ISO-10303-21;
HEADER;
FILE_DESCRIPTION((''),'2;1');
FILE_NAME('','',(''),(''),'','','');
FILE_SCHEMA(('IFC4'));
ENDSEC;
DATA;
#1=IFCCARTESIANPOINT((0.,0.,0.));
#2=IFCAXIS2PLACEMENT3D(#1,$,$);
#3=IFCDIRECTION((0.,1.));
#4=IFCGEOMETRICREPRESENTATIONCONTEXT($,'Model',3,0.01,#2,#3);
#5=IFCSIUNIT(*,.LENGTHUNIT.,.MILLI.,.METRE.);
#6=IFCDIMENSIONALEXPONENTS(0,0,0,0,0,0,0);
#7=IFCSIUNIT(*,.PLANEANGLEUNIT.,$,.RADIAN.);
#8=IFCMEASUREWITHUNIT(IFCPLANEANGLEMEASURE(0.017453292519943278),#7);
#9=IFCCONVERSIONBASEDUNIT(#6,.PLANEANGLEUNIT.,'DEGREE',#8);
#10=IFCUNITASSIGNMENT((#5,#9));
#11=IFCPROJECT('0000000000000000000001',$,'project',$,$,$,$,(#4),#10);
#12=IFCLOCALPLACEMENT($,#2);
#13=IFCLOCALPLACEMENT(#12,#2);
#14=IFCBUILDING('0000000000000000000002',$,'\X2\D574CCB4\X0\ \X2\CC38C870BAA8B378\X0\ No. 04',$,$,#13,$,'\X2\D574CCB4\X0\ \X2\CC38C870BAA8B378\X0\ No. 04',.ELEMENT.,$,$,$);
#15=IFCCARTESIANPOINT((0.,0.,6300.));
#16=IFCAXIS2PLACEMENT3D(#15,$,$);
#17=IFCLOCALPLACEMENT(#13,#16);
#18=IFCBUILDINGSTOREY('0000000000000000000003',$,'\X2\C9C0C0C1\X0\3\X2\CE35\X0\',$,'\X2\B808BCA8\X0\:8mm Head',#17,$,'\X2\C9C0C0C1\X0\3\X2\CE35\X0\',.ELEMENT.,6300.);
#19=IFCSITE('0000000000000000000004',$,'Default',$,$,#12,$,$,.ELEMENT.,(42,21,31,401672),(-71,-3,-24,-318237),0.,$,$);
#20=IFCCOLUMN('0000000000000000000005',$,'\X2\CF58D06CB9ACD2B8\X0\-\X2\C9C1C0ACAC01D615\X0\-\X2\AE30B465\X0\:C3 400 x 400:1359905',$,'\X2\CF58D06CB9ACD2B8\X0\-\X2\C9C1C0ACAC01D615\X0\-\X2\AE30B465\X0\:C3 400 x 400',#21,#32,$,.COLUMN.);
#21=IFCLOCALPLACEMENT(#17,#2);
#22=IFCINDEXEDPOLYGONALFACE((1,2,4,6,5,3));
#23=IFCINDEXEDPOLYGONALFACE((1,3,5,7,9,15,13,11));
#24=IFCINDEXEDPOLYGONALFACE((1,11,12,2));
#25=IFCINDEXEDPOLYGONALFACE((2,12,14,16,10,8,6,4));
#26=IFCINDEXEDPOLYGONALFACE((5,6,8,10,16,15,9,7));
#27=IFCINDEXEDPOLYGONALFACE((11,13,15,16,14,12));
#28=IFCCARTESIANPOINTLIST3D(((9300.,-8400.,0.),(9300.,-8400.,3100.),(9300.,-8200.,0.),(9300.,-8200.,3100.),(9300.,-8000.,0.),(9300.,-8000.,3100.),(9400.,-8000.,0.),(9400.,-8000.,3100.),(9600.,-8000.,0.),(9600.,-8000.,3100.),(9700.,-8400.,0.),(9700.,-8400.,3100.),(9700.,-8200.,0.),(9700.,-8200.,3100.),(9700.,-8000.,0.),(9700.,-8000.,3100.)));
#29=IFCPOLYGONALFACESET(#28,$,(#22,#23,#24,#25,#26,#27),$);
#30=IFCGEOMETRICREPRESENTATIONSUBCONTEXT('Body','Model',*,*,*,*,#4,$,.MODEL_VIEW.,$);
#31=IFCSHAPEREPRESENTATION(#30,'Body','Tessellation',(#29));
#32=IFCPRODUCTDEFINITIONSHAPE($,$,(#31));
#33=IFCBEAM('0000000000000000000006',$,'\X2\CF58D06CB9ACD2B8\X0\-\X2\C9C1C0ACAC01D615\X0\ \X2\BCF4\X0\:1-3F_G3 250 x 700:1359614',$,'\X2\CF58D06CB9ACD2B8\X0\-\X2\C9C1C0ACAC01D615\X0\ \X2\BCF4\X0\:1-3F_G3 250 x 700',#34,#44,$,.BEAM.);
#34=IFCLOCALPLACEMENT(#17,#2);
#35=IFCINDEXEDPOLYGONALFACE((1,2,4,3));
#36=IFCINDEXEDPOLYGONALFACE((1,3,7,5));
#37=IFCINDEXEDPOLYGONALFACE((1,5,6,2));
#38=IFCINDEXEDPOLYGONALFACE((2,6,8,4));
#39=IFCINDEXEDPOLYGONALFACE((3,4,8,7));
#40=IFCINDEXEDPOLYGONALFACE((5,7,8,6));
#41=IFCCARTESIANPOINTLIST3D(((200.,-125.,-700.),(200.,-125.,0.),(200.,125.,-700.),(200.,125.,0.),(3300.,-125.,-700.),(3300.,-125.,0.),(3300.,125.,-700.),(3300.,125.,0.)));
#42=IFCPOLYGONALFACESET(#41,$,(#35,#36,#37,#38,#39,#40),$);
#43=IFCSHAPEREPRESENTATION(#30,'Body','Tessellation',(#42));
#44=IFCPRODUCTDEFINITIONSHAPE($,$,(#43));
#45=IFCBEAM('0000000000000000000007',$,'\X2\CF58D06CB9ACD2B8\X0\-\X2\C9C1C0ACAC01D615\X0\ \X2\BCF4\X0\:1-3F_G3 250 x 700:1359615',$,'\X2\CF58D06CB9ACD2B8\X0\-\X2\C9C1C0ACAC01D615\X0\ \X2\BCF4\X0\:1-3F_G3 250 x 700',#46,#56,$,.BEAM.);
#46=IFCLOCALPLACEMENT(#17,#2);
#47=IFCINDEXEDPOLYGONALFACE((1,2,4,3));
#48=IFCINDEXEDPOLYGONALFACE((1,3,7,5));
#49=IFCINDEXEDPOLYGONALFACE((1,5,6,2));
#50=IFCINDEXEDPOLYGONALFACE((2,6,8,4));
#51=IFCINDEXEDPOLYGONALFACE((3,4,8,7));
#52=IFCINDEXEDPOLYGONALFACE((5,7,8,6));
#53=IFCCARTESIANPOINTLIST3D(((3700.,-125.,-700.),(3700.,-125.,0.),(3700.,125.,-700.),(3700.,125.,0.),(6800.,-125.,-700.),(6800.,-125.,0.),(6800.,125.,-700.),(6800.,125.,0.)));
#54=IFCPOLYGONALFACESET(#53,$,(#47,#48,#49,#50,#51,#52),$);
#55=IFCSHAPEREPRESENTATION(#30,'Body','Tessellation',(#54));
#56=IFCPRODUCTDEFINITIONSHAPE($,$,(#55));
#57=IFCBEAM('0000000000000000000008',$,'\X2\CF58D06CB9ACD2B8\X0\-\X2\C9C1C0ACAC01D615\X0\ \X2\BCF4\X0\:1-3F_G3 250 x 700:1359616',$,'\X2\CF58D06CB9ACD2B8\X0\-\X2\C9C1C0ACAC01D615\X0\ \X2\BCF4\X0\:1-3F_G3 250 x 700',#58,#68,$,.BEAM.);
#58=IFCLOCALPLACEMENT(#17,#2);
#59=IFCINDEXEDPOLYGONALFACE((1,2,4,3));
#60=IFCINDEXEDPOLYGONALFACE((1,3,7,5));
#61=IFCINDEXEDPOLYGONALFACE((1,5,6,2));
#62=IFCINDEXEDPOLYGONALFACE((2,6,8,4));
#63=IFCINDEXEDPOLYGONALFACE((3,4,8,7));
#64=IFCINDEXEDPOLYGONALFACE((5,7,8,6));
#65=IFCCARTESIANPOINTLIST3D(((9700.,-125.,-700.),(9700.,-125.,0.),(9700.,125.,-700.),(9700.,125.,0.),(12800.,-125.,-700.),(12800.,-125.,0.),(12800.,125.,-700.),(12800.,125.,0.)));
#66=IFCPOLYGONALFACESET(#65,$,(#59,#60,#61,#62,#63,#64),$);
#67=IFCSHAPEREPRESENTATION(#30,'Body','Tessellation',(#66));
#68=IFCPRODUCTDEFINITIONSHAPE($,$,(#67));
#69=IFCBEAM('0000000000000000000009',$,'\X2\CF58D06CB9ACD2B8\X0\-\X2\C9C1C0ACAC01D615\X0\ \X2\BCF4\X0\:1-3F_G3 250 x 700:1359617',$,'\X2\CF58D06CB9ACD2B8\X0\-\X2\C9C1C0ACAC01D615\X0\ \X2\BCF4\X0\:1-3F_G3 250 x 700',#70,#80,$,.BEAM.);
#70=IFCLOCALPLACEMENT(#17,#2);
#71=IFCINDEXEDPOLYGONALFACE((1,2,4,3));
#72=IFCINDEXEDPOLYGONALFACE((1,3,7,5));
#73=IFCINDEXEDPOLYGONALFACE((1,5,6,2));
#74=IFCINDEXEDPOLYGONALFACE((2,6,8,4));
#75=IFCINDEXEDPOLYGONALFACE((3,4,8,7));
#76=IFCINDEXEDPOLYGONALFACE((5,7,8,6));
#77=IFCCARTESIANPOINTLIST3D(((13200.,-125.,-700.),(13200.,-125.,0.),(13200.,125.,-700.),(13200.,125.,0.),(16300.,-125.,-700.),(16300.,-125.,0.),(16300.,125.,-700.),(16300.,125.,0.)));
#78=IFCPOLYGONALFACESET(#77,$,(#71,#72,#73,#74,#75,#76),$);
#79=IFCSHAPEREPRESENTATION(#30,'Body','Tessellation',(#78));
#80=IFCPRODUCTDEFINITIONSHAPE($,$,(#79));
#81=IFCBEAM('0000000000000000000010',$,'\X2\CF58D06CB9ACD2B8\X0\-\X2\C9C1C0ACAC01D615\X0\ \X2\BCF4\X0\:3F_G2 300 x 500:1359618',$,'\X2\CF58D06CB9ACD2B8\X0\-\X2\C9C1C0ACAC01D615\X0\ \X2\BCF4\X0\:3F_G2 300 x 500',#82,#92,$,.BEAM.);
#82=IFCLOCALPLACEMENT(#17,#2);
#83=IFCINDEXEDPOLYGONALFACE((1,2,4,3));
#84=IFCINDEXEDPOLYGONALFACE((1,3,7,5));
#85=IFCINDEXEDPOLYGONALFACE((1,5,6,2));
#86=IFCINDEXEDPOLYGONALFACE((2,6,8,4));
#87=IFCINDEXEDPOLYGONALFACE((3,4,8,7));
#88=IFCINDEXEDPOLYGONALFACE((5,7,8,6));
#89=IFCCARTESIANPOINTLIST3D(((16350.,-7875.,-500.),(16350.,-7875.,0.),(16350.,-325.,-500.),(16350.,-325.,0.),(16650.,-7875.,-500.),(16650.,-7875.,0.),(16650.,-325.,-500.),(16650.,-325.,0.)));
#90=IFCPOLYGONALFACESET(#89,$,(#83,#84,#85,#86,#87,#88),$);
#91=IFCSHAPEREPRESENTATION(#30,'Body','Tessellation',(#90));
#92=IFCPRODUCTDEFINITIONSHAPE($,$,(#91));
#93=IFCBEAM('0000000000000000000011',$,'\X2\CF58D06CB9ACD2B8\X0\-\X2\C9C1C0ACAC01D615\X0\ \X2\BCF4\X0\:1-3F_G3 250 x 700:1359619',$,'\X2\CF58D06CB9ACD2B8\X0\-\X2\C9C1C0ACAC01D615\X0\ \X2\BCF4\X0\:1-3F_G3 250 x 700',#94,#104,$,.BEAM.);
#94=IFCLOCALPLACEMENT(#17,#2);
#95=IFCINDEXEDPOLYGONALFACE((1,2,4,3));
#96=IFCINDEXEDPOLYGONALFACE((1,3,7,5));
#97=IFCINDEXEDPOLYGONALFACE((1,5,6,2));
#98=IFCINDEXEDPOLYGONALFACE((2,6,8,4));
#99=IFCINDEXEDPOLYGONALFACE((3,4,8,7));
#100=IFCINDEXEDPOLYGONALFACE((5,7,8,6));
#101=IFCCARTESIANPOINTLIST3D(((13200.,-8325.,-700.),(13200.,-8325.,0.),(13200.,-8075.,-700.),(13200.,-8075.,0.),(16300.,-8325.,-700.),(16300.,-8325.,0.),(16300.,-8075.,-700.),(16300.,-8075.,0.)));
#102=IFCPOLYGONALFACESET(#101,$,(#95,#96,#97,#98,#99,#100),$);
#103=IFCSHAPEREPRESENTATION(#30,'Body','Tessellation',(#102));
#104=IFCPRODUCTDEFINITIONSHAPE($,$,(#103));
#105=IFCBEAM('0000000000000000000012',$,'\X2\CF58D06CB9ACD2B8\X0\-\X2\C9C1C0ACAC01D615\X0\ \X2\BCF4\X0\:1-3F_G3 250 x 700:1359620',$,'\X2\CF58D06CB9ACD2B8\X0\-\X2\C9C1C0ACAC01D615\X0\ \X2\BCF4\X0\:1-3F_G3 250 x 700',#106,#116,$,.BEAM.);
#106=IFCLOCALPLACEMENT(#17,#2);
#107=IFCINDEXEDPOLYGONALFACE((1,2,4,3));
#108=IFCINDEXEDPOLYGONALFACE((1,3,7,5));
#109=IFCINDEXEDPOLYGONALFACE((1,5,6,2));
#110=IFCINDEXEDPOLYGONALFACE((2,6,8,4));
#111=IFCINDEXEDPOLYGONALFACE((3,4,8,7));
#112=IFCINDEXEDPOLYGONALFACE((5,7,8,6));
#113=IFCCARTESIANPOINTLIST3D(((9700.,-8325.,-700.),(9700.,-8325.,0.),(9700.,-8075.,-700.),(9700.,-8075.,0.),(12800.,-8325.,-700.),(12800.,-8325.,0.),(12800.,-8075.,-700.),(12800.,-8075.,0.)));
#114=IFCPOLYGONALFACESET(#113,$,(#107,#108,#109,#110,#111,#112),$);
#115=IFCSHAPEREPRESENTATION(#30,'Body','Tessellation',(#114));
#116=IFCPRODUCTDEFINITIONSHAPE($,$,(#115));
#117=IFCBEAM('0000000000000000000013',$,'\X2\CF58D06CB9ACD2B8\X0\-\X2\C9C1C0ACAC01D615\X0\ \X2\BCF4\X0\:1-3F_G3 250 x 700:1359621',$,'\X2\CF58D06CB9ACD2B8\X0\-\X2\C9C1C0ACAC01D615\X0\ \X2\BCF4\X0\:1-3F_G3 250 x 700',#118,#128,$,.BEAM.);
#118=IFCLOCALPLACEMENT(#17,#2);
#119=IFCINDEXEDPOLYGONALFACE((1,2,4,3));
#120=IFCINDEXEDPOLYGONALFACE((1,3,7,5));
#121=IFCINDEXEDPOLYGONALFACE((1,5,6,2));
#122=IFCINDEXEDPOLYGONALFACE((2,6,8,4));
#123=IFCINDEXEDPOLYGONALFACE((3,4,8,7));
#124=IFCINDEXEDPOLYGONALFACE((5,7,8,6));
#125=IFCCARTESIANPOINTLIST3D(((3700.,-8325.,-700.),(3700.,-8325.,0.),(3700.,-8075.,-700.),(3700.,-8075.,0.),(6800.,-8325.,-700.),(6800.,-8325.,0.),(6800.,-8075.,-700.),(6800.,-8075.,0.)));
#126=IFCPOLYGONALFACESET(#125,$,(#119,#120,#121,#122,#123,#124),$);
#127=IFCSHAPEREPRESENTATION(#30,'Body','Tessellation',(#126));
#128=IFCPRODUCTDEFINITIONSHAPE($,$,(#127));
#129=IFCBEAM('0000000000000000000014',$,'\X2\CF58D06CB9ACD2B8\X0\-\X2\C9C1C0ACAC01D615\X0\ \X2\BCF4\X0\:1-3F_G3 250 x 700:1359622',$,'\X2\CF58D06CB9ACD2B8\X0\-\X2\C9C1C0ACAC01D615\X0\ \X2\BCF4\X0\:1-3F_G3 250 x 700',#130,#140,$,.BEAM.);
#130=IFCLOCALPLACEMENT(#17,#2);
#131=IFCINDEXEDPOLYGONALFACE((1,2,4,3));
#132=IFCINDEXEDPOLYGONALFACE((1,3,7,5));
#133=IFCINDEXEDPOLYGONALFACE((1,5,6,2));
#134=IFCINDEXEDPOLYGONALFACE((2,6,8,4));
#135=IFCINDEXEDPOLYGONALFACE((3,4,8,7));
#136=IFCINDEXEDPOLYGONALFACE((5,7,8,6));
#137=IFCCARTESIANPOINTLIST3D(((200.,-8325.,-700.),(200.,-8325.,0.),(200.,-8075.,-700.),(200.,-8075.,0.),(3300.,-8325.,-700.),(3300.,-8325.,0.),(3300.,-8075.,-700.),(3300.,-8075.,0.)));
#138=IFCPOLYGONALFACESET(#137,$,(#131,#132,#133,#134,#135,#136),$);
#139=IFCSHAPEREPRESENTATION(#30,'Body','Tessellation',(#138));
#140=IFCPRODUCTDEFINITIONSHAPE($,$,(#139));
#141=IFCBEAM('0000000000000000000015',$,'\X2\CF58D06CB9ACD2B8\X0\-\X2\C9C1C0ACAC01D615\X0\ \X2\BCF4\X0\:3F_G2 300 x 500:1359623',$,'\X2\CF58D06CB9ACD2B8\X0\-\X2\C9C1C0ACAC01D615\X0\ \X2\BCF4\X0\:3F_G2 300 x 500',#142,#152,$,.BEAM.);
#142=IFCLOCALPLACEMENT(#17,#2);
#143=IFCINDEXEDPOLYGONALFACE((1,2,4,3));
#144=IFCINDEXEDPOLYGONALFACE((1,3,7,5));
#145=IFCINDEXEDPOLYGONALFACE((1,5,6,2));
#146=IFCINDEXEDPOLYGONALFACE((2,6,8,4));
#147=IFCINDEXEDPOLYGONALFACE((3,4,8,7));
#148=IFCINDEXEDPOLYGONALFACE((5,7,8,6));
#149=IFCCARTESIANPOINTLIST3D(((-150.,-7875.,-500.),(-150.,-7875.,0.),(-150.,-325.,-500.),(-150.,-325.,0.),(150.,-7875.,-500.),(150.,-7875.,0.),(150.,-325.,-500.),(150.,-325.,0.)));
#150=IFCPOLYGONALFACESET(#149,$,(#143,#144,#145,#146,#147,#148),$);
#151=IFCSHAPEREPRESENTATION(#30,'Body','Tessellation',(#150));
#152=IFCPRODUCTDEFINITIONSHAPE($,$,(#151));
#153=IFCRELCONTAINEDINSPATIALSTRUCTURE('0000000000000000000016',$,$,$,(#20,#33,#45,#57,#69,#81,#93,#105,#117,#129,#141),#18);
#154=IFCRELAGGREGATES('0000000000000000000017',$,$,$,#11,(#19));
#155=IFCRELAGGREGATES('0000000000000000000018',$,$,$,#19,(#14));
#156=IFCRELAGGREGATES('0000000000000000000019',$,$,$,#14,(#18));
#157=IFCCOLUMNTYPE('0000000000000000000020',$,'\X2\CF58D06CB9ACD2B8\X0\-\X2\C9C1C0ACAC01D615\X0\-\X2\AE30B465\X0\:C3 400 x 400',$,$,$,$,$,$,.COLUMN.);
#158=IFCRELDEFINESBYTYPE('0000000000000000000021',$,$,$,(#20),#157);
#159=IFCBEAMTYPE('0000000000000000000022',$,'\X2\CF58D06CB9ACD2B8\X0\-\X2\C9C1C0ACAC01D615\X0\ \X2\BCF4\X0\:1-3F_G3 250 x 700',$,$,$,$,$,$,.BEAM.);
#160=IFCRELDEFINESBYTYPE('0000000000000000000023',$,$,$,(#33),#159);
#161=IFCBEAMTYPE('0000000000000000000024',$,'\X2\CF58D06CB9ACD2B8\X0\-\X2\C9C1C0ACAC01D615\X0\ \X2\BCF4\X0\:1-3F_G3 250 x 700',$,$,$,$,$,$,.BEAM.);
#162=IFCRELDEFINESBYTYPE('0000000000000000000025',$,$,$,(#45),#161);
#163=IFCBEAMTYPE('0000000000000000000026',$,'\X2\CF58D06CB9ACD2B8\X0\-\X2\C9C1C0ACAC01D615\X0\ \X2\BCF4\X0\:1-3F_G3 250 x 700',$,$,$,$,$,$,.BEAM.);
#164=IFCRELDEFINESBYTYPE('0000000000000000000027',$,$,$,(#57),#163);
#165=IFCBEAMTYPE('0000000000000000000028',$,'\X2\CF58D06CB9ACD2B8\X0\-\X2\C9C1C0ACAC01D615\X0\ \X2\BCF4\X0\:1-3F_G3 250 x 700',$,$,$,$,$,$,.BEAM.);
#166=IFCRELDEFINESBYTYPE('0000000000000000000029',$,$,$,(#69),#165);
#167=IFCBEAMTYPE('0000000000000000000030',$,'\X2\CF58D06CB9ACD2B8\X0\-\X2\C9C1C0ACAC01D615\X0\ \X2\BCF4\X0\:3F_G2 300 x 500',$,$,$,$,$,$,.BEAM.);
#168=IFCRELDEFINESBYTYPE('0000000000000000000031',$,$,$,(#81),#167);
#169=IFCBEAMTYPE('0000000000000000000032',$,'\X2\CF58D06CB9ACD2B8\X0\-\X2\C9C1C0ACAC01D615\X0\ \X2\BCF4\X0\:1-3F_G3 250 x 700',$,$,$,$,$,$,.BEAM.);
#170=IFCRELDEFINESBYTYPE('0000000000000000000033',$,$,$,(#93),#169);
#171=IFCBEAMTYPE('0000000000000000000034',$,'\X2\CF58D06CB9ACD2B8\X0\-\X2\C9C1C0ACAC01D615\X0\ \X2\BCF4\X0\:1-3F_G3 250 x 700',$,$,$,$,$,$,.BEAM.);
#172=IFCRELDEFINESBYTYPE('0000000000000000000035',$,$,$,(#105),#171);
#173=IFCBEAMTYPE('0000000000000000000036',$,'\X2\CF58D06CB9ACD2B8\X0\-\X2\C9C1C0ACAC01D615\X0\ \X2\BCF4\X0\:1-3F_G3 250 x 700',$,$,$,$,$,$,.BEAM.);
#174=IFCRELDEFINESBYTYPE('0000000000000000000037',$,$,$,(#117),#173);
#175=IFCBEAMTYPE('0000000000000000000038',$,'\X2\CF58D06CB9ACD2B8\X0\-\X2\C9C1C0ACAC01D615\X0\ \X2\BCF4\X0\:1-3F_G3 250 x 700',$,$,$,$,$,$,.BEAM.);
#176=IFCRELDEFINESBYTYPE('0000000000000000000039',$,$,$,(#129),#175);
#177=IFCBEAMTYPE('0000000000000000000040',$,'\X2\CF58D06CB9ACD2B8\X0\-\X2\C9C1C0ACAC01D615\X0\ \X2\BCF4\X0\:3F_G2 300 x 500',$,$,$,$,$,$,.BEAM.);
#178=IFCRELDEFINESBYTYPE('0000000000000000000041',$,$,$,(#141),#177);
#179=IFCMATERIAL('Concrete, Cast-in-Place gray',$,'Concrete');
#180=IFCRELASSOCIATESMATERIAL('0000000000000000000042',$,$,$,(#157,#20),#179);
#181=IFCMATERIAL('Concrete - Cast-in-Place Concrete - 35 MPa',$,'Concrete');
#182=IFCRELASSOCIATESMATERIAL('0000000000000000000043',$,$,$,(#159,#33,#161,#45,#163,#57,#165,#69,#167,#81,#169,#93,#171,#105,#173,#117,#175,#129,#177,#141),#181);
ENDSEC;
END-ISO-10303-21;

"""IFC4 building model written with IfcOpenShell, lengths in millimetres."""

from ifc_helpers import new_model, entity, si_unit, converted_unit, direction, frame, origin, place, context, subcontext, project, spatial, indexed_curve, outline, extrude, source, transform, mapped, material, type_object, type_shapes, element, save


model = new_model("IFC4")

# Units and contexts
model_context = context("Model", 3, precision=0.01, world=origin(), true_north=direction((0.0, 1.0)))
body_context = subcontext(model_context, "Body", "Model", "MODEL_VIEW")
ifc_project = project(units=[si_unit("LENGTHUNIT", "METRE", prefix="MILLI"), converted_unit("PLANEANGLEUNIT", "DEGREE", entity("IfcPlaneAngleMeasure", 0.017453292519943278), si_unit("PLANEANGLEUNIT", "RADIAN"), dimensions=[0, 0, 0, 0, 0, 0, 0])], contexts=[model_context])

# Site, building, storey
site_placement = place(None, origin())
site = spatial("IfcSite", under=ifc_project, at=site_placement, Name="Default", CompositionType="ELEMENT", RefLatitude=(42, 21, 31, 401672), RefLongitude=(-71, -3, -24, -318237), RefElevation=0.0)
building_placement = place(site_placement, origin())
building = spatial("IfcBuilding", under=site, at=building_placement, Name="해체 참조모델 No. 04", LongName="해체 참조모델 No. 04", CompositionType="ELEMENT")
storey_placement = place(building_placement, frame((0.0, 0.0, 6300.0)))
storey = spatial("IfcBuildingStorey", under=building, at=storey_placement, Name="지상3층", ObjectType="레벨:8mm Head", LongName="지상3층", CompositionType="ELEMENT", Elevation=6300.0)

# Column
ifc_material_1 = material(Name="Concrete, Cast-in-Place gray", Category="Concrete")
column_type_1 = type_object("IfcColumnType", Name="콘크리트-직사각형-기둥:C3 400 x 400", PredefinedType="COLUMN", material=ifc_material_1)
shared_shape_1 = source(origin(), body_context, "Body", "SweptSolid", [
    extrude(outline(indexed_curve([(-200.0, -150.0), (-100.0, -150.0), (100.0, -150.0), (200.0, -150.0), (200.0, 50.0), (200.0, 250.0), (-200.0, 250.0), (-200.0, 50.0), (-200.0, -150.0)], self_intersect=False)), frame((9500.0, -8150.0, 6300.0), z_axis=(0.0, 0.0, 1.0), x_axis=(-1.0, 0.0, 0.0)), (0.0, 0.0, 1.0), 3100.0),
])
type_shapes(column_type_1, [shared_shape_1])
column_1_placement = place(storey_placement, frame((0.0, 0.0, -6300.0)))
element("IfcColumn", 1, at=column_1_placement, inside=storey, type_object=column_type_1, material=ifc_material_1, Name="콘크리트-직사각형-기둥:C3 400 x 400:1359905", ObjectType="콘크리트-직사각형-기둥:C3 400 x 400", PredefinedType="COLUMN", context=body_context, shape_type="MappedRepresentation", body=[
    mapped(shared_shape_1, transform((0.0, 0.0, 0.0), scale=1.0)),
])

# Beams
ifc_material_2 = material(Name="Concrete - Cast-in-Place Concrete - 35 MPa", Category="Concrete")
beam_type_1 = type_object("IfcBeamType", Name="콘크리트-직사각형 보:1-3F_G3 250 x 700", PredefinedType="BEAM", material=ifc_material_2)
shared_shape_2 = source(origin(), body_context, "Body", "SweptSolid", [
    extrude(outline(indexed_curve([(-350.0, -125.0), (350.0, -125.0), (350.0, 125.0), (-350.0, 125.0), (-350.0, -125.0)], self_intersect=False)), frame((200.0, 0.0, 5950.0), z_axis=(1.0, 0.0, 0.0), x_axis=(0.0, 0.0, -1.0)), (0.0, 0.0, 1.0), 3100.0),
])
type_shapes(beam_type_1, [shared_shape_2])
beam_1_placement = place(storey_placement, frame((0.0, 0.0, -6300.0)))
element("IfcBeam", 2, at=beam_1_placement, inside=storey, type_object=beam_type_1, material=ifc_material_2, Name="콘크리트-직사각형 보:1-3F_G3 250 x 700:1359614", ObjectType="콘크리트-직사각형 보:1-3F_G3 250 x 700", PredefinedType="BEAM", context=body_context, shape_type="MappedRepresentation", body=[
    mapped(shared_shape_2, transform((0.0, 0.0, 0.0), scale=1.0)),
])
beam_type_2 = type_object("IfcBeamType", Name="콘크리트-직사각형 보:1-3F_G3 250 x 700", PredefinedType="BEAM", material=ifc_material_2)
shared_shape_3 = source(origin(), body_context, "Body", "SweptSolid", [
    extrude(outline(indexed_curve([(-350.0, -125.0), (350.0, -125.0), (350.0, 125.0), (-350.0, 125.0), (-350.0, -125.0)], self_intersect=False)), frame((3700.0, 0.0, 5950.0), z_axis=(1.0, 0.0, 0.0), x_axis=(0.0, 0.0, -1.0)), (0.0, 0.0, 1.0), 3100.0),
])
type_shapes(beam_type_2, [shared_shape_3])
beam_2_placement = place(storey_placement, frame((0.0, 0.0, -6300.0)))
element("IfcBeam", 3, at=beam_2_placement, inside=storey, type_object=beam_type_2, material=ifc_material_2, Name="콘크리트-직사각형 보:1-3F_G3 250 x 700:1359615", ObjectType="콘크리트-직사각형 보:1-3F_G3 250 x 700", PredefinedType="BEAM", context=body_context, shape_type="MappedRepresentation", body=[
    mapped(shared_shape_3, transform((0.0, 0.0, 0.0), scale=1.0)),
])
beam_type_3 = type_object("IfcBeamType", Name="콘크리트-직사각형 보:1-3F_G3 250 x 700", PredefinedType="BEAM", material=ifc_material_2)
shared_shape_4 = source(origin(), body_context, "Body", "SweptSolid", [
    extrude(outline(indexed_curve([(-350.0, -125.0), (350.0, -125.0), (350.0, 125.0), (-350.0, 125.0), (-350.0, -125.0)], self_intersect=False)), frame((9700.0, 0.0, 5950.0), z_axis=(1.0, 0.0, 0.0), x_axis=(0.0, 0.0, -1.0)), (0.0, 0.0, 1.0), 3100.0),
])
type_shapes(beam_type_3, [shared_shape_4])
beam_3_placement = place(storey_placement, frame((0.0, 0.0, -6300.0)))
element("IfcBeam", 4, at=beam_3_placement, inside=storey, type_object=beam_type_3, material=ifc_material_2, Name="콘크리트-직사각형 보:1-3F_G3 250 x 700:1359616", ObjectType="콘크리트-직사각형 보:1-3F_G3 250 x 700", PredefinedType="BEAM", context=body_context, shape_type="MappedRepresentation", body=[
    mapped(shared_shape_4, transform((0.0, 0.0, 0.0), scale=1.0)),
])
beam_type_4 = type_object("IfcBeamType", Name="콘크리트-직사각형 보:1-3F_G3 250 x 700", PredefinedType="BEAM", material=ifc_material_2)
shared_shape_5 = source(origin(), body_context, "Body", "SweptSolid", [
    extrude(outline(indexed_curve([(-350.0, -125.0), (350.0, -125.0), (350.0, 125.0), (-350.0, 125.0), (-350.0, -125.0)], self_intersect=False)), frame((13200.0, 0.0, 5950.0), z_axis=(1.0, 0.0, 0.0), x_axis=(0.0, 0.0, -1.0)), (0.0, 0.0, 1.0), 3100.0),
])
type_shapes(beam_type_4, [shared_shape_5])
beam_4_placement = place(storey_placement, frame((0.0, 0.0, -6300.0)))
element("IfcBeam", 5, at=beam_4_placement, inside=storey, type_object=beam_type_4, material=ifc_material_2, Name="콘크리트-직사각형 보:1-3F_G3 250 x 700:1359617", ObjectType="콘크리트-직사각형 보:1-3F_G3 250 x 700", PredefinedType="BEAM", context=body_context, shape_type="MappedRepresentation", body=[
    mapped(shared_shape_5, transform((0.0, 0.0, 0.0), scale=1.0)),
])
beam_type_5 = type_object("IfcBeamType", Name="콘크리트-직사각형 보:3F_G2 300 x 500", PredefinedType="BEAM", material=ifc_material_2)
shared_shape_6 = source(origin(), body_context, "Body", "SweptSolid", [
    extrude(outline(indexed_curve([(-150.0, -250.0), (150.0, -250.0), (150.0, 250.0), (-150.0, 250.0), (-150.0, -250.0)], self_intersect=False)), frame((16500.0, -325.0, 6050.0), z_axis=(0.0, -1.0, 0.0), x_axis=(-1.0, 0.0, 0.0)), (0.0, 0.0, 1.0), 7550.0),
])
type_shapes(beam_type_5, [shared_shape_6])
beam_5_placement = place(storey_placement, frame((0.0, 0.0, -6300.0)))
element("IfcBeam", 6, at=beam_5_placement, inside=storey, type_object=beam_type_5, material=ifc_material_2, Name="콘크리트-직사각형 보:3F_G2 300 x 500:1359618", ObjectType="콘크리트-직사각형 보:3F_G2 300 x 500", PredefinedType="BEAM", context=body_context, shape_type="MappedRepresentation", body=[
    mapped(shared_shape_6, transform((0.0, 0.0, 0.0), scale=1.0)),
])
beam_type_6 = type_object("IfcBeamType", Name="콘크리트-직사각형 보:1-3F_G3 250 x 700", PredefinedType="BEAM", material=ifc_material_2)
shared_shape_7 = source(origin(), body_context, "Body", "SweptSolid", [
    extrude(outline(indexed_curve([(-350.0, -125.0), (350.0, -125.0), (350.0, 125.0), (-350.0, 125.0), (-350.0, -125.0)], self_intersect=False)), frame((16300.0, -8200.0, 5950.0), z_axis=(-1.0, 0.0, 0.0), x_axis=(0.0, 0.0, -1.0)), (0.0, 0.0, 1.0), 3100.0),
])
type_shapes(beam_type_6, [shared_shape_7])
beam_6_placement = place(storey_placement, frame((0.0, 0.0, -6300.0)))
element("IfcBeam", 7, at=beam_6_placement, inside=storey, type_object=beam_type_6, material=ifc_material_2, Name="콘크리트-직사각형 보:1-3F_G3 250 x 700:1359619", ObjectType="콘크리트-직사각형 보:1-3F_G3 250 x 700", PredefinedType="BEAM", context=body_context, shape_type="MappedRepresentation", body=[
    mapped(shared_shape_7, transform((0.0, 0.0, 0.0), scale=1.0)),
])
beam_type_7 = type_object("IfcBeamType", Name="콘크리트-직사각형 보:1-3F_G3 250 x 700", PredefinedType="BEAM", material=ifc_material_2)
shared_shape_8 = source(origin(), body_context, "Body", "SweptSolid", [
    extrude(outline(indexed_curve([(-350.0, -125.0), (350.0, -125.0), (350.0, 125.0), (-350.0, 125.0), (-350.0, -125.0)], self_intersect=False)), frame((12800.0, -8200.0, 5950.0), z_axis=(-1.0, 0.0, 0.0), x_axis=(0.0, 0.0, -1.0)), (0.0, 0.0, 1.0), 3100.0),
])
type_shapes(beam_type_7, [shared_shape_8])
beam_7_placement = place(storey_placement, frame((0.0, 0.0, -6300.0)))
element("IfcBeam", 8, at=beam_7_placement, inside=storey, type_object=beam_type_7, material=ifc_material_2, Name="콘크리트-직사각형 보:1-3F_G3 250 x 700:1359620", ObjectType="콘크리트-직사각형 보:1-3F_G3 250 x 700", PredefinedType="BEAM", context=body_context, shape_type="MappedRepresentation", body=[
    mapped(shared_shape_8, transform((0.0, 0.0, 0.0), scale=1.0)),
])
beam_type_8 = type_object("IfcBeamType", Name="콘크리트-직사각형 보:1-3F_G3 250 x 700", PredefinedType="BEAM", material=ifc_material_2)
shared_shape_9 = source(origin(), body_context, "Body", "SweptSolid", [
    extrude(outline(indexed_curve([(-350.0, -125.0), (350.0, -125.0), (350.0, 125.0), (-350.0, 125.0), (-350.0, -125.0)], self_intersect=False)), frame((6800.0, -8200.0, 5950.0), z_axis=(-1.0, 0.0, 0.0), x_axis=(0.0, 0.0, -1.0)), (0.0, 0.0, 1.0), 3100.0),
])
type_shapes(beam_type_8, [shared_shape_9])
beam_8_placement = place(storey_placement, frame((0.0, 0.0, -6300.0)))
element("IfcBeam", 9, at=beam_8_placement, inside=storey, type_object=beam_type_8, material=ifc_material_2, Name="콘크리트-직사각형 보:1-3F_G3 250 x 700:1359621", ObjectType="콘크리트-직사각형 보:1-3F_G3 250 x 700", PredefinedType="BEAM", context=body_context, shape_type="MappedRepresentation", body=[
    mapped(shared_shape_9, transform((0.0, 0.0, 0.0), scale=1.0)),
])
beam_type_9 = type_object("IfcBeamType", Name="콘크리트-직사각형 보:1-3F_G3 250 x 700", PredefinedType="BEAM", material=ifc_material_2)
shared_shape_10 = source(origin(), body_context, "Body", "SweptSolid", [
    extrude(outline(indexed_curve([(-350.0, -125.0), (350.0, -125.0), (350.0, 125.0), (-350.0, 125.0), (-350.0, -125.0)], self_intersect=False)), frame((3300.0, -8200.0, 5950.0), z_axis=(-1.0, 0.0, 0.0), x_axis=(0.0, 0.0, -1.0)), (0.0, 0.0, 1.0), 3100.0),
])
type_shapes(beam_type_9, [shared_shape_10])
beam_9_placement = place(storey_placement, frame((0.0, 0.0, -6300.0)))
element("IfcBeam", 10, at=beam_9_placement, inside=storey, type_object=beam_type_9, material=ifc_material_2, Name="콘크리트-직사각형 보:1-3F_G3 250 x 700:1359622", ObjectType="콘크리트-직사각형 보:1-3F_G3 250 x 700", PredefinedType="BEAM", context=body_context, shape_type="MappedRepresentation", body=[
    mapped(shared_shape_10, transform((0.0, 0.0, 0.0), scale=1.0)),
])
beam_type_10 = type_object("IfcBeamType", Name="콘크리트-직사각형 보:3F_G2 300 x 500", PredefinedType="BEAM", material=ifc_material_2)
shared_shape_11 = source(origin(), body_context, "Body", "SweptSolid", [
    extrude(outline(indexed_curve([(-150.0, -250.0), (150.0, -250.0), (150.0, 250.0), (-150.0, 250.0), (-150.0, -250.0)], self_intersect=False)), frame((0.0, -7875.0, 6050.0), z_axis=(0.0, 1.0, 0.0), x_axis=(-1.0, 0.0, 0.0)), (0.0, 0.0, 1.0), 7550.0),
])
type_shapes(beam_type_10, [shared_shape_11])
beam_10_placement = place(storey_placement, frame((0.0, 0.0, -6300.0)))
element("IfcBeam", 11, at=beam_10_placement, inside=storey, type_object=beam_type_10, material=ifc_material_2, Name="콘크리트-직사각형 보:3F_G2 300 x 500:1359623", ObjectType="콘크리트-직사각형 보:3F_G2 300 x 500", PredefinedType="BEAM", context=body_context, shape_type="MappedRepresentation", body=[
    mapped(shared_shape_11, transform((0.0, 0.0, 0.0), scale=1.0)),
])

save(model, "model.ifc")
